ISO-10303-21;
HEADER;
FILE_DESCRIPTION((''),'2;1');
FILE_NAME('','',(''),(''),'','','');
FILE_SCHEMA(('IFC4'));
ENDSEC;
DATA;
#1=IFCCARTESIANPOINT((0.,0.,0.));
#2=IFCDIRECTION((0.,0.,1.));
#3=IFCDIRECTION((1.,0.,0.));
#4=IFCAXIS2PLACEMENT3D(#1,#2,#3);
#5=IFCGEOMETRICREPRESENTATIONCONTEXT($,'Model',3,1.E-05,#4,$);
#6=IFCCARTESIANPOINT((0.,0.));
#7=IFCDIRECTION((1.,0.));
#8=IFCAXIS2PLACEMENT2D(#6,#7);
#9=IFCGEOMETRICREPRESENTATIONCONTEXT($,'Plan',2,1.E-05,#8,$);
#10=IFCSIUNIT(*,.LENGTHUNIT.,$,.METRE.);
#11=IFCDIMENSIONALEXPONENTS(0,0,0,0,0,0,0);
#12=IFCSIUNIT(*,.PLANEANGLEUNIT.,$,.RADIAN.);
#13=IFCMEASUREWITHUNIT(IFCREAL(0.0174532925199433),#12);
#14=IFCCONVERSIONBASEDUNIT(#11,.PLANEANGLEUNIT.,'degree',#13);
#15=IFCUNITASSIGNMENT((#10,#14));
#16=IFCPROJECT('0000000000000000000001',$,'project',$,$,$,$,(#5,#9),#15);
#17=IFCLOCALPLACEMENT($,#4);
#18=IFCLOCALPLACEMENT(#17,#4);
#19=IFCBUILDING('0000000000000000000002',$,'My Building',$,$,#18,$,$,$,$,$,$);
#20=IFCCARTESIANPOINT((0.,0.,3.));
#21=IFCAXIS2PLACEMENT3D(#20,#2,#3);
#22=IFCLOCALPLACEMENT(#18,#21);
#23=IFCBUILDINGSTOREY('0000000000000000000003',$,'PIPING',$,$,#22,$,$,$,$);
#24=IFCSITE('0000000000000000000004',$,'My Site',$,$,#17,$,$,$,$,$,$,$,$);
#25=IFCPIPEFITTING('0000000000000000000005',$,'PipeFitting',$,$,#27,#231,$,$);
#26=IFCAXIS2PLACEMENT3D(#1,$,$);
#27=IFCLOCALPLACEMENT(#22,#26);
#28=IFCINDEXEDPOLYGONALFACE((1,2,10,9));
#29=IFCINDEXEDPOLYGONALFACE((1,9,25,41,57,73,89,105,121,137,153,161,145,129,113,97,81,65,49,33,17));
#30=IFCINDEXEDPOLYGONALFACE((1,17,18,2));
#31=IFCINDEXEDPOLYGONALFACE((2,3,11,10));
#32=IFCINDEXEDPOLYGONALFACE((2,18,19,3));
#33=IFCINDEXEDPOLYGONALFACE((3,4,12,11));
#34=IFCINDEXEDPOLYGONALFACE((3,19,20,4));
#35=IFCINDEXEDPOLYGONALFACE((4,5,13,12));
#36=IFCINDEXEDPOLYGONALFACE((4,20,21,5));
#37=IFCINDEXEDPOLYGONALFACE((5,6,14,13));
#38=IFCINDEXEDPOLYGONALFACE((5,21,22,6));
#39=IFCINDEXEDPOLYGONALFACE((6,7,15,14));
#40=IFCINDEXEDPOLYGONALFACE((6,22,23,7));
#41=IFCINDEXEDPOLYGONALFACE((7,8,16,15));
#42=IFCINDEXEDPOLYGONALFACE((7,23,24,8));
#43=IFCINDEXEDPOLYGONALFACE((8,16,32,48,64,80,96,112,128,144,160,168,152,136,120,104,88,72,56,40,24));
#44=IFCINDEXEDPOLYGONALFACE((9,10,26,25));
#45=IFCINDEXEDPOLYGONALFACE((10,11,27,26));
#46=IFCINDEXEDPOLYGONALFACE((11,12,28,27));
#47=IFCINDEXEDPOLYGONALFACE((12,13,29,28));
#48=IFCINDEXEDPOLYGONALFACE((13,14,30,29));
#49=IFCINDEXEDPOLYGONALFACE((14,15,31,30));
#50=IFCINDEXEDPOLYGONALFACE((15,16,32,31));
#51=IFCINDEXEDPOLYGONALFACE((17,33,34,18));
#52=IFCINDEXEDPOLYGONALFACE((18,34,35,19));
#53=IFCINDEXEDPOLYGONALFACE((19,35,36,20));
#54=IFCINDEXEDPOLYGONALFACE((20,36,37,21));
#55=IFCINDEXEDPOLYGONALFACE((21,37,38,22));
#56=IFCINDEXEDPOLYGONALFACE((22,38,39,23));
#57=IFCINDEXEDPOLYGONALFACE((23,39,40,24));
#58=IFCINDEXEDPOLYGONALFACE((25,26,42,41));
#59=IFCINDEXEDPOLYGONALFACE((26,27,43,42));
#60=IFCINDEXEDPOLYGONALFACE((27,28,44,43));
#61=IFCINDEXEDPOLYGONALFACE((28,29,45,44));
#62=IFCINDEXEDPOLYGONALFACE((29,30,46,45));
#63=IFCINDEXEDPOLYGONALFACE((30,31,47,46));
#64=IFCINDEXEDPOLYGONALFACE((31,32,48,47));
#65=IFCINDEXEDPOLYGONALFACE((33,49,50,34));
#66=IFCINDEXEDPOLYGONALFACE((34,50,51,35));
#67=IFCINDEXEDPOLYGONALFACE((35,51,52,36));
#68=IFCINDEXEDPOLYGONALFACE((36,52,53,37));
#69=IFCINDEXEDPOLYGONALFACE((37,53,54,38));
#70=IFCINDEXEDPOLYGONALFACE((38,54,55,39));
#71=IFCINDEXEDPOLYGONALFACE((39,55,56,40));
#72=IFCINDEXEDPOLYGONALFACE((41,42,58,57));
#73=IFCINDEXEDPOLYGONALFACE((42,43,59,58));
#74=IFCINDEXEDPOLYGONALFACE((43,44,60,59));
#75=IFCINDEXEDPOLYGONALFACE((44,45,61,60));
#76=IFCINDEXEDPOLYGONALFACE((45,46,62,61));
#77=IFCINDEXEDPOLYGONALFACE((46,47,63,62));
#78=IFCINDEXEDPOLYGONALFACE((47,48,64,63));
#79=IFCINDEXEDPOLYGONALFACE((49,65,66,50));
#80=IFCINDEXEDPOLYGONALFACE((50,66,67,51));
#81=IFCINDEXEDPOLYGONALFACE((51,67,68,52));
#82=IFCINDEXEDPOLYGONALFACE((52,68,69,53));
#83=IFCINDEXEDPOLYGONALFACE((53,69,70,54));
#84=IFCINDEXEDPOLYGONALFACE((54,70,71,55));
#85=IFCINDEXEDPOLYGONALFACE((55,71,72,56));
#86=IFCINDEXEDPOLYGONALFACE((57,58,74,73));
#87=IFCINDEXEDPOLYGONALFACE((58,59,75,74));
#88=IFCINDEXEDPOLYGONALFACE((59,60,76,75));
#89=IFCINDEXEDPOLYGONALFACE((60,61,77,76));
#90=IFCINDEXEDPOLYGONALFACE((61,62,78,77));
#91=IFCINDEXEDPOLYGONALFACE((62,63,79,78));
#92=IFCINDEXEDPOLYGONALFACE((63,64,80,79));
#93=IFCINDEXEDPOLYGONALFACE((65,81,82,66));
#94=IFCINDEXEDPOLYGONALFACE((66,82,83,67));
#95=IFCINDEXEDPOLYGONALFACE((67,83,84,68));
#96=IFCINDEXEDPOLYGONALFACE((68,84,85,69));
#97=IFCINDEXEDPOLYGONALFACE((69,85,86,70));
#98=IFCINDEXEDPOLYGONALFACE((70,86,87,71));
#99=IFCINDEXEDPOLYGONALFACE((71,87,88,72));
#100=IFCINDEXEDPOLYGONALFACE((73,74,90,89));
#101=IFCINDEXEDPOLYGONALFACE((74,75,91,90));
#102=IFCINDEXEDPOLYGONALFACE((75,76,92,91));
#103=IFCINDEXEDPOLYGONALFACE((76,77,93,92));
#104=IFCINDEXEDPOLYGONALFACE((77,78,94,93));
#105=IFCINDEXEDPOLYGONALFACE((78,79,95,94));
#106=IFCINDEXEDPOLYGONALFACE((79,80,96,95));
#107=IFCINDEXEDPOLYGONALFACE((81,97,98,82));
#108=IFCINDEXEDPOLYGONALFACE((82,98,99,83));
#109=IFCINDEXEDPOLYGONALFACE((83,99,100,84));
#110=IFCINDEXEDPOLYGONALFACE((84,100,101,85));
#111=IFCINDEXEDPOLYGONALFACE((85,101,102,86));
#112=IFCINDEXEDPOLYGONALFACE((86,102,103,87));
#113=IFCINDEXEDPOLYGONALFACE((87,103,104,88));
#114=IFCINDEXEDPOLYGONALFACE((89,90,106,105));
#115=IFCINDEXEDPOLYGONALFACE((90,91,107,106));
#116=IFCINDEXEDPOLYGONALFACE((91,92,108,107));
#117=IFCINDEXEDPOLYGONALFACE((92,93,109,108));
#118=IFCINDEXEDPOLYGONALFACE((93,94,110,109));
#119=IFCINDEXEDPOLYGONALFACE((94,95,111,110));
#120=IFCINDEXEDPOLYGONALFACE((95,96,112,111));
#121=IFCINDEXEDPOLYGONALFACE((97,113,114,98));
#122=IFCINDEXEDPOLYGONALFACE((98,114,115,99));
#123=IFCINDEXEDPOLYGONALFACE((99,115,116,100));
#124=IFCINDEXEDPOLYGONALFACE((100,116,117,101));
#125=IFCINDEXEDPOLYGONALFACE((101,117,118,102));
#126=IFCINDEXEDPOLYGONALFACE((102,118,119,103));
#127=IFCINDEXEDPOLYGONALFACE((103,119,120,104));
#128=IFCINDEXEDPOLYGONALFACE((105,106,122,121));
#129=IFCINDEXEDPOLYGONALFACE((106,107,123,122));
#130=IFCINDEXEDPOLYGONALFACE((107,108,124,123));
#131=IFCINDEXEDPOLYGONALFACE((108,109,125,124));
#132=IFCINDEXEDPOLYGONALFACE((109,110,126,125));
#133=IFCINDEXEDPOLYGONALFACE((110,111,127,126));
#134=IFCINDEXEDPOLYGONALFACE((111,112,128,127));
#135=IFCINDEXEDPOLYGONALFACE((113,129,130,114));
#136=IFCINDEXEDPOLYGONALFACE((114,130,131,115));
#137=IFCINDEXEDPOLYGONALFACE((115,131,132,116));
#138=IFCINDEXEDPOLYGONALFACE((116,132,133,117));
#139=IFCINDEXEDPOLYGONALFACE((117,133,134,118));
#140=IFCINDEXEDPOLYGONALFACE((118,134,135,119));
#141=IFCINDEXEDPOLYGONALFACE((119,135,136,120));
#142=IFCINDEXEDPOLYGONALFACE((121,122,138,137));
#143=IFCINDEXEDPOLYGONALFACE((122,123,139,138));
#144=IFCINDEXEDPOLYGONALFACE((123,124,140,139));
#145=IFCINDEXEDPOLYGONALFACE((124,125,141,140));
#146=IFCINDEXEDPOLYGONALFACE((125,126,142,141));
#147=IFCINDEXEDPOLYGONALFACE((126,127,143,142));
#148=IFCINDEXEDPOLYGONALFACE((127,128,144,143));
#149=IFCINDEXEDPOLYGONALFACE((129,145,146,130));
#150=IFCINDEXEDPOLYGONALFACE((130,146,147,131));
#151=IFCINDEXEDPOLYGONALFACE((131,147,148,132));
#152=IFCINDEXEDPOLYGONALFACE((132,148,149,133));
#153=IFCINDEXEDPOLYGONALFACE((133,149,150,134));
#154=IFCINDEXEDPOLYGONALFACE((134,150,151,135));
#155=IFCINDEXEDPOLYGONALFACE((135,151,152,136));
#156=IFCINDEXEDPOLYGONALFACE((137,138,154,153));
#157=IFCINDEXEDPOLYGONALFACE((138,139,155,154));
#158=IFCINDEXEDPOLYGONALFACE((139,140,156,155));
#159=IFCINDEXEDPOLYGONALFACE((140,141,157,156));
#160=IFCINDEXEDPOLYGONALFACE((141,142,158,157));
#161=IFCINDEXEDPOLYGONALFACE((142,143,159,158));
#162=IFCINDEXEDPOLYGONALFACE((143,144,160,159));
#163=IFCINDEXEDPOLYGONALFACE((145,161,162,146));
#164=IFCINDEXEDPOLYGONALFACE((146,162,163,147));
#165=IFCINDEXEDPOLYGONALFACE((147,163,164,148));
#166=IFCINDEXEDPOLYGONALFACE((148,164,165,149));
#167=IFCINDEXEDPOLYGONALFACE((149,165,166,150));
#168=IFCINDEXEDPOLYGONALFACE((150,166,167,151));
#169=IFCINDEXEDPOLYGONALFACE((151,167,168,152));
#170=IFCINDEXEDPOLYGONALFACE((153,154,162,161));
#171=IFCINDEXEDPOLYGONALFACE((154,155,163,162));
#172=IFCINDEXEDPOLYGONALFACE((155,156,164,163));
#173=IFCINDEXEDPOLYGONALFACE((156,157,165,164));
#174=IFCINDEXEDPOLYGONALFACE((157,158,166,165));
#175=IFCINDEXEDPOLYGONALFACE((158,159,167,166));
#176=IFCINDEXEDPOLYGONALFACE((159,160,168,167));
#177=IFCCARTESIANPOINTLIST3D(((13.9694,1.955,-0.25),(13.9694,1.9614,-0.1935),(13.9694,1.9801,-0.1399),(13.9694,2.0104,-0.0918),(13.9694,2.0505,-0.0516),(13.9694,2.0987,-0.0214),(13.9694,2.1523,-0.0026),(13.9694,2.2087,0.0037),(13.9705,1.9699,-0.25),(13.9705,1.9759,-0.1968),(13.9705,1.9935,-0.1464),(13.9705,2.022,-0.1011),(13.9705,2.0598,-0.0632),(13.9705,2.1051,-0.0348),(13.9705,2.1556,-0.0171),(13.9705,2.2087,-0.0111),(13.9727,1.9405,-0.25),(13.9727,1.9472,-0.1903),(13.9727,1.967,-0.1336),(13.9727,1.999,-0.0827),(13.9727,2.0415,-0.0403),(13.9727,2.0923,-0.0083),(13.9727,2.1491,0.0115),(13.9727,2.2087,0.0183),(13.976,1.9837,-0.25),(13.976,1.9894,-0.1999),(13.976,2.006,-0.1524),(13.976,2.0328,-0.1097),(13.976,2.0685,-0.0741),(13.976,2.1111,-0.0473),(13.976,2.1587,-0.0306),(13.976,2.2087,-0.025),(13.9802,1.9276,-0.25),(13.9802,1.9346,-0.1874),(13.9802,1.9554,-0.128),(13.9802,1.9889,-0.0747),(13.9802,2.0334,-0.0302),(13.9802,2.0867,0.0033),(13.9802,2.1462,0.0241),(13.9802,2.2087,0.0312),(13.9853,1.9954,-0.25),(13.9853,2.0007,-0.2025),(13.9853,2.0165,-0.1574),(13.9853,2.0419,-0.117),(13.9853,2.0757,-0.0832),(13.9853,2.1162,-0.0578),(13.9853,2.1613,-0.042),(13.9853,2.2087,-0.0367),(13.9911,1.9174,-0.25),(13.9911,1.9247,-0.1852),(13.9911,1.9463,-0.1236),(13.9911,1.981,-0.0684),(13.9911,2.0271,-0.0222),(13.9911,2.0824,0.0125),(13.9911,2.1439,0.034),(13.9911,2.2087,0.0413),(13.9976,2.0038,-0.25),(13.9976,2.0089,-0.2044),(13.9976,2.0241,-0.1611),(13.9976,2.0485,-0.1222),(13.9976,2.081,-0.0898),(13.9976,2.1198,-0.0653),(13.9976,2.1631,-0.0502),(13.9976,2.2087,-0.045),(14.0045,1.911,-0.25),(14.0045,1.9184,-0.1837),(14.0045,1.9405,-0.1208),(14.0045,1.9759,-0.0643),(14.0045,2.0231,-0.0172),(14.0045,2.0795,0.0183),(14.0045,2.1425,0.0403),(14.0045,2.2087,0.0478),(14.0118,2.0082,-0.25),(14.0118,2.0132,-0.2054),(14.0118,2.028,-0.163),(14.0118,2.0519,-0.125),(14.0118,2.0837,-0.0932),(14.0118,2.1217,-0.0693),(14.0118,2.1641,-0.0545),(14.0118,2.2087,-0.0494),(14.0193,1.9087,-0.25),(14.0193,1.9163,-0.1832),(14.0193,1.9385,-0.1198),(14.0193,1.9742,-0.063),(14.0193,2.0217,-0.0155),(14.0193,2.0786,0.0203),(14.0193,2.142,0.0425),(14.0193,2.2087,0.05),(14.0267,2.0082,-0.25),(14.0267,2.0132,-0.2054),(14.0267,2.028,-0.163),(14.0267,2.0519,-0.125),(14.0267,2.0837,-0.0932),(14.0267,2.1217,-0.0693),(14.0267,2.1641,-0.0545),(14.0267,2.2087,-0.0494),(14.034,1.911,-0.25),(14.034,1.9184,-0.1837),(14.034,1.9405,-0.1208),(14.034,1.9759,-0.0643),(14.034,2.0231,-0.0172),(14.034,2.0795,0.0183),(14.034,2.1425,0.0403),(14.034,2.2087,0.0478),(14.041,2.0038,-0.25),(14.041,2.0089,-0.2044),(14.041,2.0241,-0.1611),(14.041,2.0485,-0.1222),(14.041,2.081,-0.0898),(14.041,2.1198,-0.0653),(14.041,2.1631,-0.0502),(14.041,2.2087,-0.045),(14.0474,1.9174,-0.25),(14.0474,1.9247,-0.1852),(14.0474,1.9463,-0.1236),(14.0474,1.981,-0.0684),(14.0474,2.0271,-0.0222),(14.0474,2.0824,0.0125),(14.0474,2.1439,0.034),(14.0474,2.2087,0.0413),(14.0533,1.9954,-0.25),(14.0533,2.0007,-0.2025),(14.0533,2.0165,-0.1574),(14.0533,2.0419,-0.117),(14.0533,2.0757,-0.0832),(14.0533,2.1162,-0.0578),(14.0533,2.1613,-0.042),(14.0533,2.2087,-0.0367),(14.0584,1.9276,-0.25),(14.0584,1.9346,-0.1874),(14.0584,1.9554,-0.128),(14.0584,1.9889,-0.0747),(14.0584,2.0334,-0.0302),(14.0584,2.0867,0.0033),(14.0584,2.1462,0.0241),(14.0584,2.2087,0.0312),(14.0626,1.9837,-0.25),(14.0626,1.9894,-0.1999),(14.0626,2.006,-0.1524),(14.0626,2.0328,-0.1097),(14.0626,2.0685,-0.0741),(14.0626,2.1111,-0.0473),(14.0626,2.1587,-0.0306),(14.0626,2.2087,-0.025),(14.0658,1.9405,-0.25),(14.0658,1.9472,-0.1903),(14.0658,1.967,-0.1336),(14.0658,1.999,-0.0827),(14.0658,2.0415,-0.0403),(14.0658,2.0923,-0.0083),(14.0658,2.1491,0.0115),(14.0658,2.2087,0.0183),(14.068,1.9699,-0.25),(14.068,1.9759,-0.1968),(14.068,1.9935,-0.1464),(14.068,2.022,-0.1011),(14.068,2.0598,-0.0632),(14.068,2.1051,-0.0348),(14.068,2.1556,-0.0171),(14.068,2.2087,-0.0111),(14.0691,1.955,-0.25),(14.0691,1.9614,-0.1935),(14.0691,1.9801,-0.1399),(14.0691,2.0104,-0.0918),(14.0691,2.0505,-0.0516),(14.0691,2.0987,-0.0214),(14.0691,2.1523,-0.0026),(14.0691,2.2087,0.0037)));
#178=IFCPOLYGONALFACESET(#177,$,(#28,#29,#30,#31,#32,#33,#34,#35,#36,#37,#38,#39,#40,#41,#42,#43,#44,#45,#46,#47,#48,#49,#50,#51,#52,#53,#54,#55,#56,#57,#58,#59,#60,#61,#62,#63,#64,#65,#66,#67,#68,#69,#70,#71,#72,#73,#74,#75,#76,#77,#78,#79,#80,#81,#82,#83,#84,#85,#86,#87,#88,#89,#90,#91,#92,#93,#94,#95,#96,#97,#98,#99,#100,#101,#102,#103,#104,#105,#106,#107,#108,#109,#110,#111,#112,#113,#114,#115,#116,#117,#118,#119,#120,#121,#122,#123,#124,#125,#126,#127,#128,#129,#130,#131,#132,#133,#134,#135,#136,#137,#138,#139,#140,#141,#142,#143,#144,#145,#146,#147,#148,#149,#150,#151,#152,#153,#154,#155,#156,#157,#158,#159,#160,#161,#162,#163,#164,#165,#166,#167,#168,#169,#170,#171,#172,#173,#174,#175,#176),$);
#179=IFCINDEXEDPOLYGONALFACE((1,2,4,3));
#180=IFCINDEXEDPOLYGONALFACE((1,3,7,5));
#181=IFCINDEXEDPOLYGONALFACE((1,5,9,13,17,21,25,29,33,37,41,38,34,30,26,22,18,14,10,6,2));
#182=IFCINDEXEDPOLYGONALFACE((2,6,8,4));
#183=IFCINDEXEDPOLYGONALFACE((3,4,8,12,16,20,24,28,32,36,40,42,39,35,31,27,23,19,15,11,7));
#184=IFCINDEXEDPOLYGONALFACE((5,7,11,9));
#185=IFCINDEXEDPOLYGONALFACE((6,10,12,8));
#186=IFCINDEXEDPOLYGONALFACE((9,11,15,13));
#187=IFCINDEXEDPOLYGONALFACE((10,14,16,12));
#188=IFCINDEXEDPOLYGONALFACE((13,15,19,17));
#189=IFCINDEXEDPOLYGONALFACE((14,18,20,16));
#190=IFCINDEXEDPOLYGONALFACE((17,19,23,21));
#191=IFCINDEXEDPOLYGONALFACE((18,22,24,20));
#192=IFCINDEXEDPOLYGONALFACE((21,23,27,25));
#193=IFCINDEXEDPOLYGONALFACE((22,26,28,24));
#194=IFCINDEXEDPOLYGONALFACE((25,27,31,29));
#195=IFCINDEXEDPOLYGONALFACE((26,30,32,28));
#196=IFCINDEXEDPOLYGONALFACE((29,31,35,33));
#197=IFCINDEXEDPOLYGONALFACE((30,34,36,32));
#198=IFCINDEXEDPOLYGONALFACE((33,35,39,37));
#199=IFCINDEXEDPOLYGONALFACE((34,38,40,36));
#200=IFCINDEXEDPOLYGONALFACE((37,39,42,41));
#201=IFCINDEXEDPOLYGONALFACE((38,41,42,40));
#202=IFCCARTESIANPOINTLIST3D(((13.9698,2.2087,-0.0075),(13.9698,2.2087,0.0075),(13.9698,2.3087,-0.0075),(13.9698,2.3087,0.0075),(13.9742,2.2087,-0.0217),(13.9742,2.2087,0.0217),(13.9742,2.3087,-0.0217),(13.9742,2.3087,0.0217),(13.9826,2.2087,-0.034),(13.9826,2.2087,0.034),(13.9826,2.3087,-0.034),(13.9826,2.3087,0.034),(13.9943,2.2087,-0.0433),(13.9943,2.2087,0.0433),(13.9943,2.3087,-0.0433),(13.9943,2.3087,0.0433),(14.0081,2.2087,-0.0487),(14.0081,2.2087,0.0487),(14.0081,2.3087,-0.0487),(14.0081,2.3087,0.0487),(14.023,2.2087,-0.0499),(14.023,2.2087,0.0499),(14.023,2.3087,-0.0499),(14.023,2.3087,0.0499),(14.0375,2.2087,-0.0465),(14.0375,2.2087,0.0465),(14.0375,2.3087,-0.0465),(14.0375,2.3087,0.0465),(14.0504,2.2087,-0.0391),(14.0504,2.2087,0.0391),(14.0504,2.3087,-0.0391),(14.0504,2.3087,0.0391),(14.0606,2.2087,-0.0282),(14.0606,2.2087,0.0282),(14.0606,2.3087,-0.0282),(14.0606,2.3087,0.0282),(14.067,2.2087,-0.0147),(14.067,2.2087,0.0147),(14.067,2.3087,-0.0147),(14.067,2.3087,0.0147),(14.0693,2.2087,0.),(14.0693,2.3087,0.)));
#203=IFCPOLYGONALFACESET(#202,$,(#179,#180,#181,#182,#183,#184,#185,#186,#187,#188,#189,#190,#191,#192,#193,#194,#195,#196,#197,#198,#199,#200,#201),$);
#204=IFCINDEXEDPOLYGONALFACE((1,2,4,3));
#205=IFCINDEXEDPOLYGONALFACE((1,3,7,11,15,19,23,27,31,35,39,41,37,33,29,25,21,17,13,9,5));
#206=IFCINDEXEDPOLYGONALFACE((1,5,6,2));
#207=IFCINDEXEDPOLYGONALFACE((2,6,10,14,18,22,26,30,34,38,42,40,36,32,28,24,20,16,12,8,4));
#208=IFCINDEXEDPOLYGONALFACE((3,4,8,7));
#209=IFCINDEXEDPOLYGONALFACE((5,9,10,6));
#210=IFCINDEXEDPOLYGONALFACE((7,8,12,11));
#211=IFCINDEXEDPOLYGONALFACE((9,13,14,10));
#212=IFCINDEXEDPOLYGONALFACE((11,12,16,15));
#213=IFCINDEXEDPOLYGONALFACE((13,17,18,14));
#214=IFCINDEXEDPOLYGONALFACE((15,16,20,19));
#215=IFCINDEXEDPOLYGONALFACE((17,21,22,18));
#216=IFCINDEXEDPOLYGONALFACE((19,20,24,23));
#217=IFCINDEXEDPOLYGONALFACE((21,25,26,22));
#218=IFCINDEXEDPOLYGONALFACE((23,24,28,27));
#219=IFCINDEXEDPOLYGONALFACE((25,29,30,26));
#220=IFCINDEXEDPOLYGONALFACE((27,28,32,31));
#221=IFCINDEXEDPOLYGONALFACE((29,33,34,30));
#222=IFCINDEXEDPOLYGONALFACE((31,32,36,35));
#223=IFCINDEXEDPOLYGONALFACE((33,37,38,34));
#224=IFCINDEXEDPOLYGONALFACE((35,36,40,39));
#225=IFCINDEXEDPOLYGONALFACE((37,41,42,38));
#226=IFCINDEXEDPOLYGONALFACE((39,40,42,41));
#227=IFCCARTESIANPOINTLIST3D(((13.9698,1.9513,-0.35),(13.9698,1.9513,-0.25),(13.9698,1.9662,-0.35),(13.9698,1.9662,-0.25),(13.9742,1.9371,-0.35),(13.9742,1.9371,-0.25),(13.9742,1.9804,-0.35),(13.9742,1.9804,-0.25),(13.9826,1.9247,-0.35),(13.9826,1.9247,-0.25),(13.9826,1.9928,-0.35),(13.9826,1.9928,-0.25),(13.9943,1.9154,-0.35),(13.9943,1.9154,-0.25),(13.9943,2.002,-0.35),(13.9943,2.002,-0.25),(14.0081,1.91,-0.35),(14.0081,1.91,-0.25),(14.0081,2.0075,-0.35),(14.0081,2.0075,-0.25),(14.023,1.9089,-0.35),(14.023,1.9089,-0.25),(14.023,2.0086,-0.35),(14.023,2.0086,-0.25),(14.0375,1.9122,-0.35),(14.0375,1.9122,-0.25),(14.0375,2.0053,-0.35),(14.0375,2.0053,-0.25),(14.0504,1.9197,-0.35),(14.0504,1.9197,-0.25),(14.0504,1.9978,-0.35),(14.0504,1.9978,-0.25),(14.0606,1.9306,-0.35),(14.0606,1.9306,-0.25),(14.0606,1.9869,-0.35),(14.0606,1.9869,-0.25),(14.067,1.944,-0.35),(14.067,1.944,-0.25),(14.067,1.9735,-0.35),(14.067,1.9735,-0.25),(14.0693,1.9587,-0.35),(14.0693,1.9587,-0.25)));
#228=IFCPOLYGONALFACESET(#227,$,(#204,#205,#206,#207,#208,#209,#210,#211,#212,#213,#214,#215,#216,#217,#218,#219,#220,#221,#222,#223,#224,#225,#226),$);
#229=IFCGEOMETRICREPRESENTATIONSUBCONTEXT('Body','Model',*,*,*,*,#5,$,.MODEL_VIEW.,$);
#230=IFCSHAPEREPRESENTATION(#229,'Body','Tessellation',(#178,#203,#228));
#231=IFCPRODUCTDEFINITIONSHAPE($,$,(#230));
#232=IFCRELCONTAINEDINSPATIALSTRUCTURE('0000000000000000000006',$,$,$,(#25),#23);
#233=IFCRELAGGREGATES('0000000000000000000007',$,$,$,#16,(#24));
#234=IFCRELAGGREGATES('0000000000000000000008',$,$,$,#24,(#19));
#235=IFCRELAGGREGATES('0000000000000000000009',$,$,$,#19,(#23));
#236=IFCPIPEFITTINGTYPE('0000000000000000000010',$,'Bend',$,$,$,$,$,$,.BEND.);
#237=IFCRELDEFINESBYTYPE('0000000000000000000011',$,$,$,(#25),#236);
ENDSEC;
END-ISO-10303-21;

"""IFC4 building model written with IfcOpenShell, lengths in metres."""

from ifc_helpers import new_model, entity, si_unit, converted_unit, frame, origin_with_axes, origin_2d_with_axis, place, context, subcontext, project, spatial, circle, extrude, source, transform, mapped, type_object, type_shapes, element, save


model = new_model("IFC4")

# Units and contexts
model_context = context("Model", 3, precision=1e-05, world=origin_with_axes())
plan_context = context("Plan", 2, precision=1e-05, world=origin_2d_with_axis())
body_context = subcontext(model_context, "Body", "Model", "MODEL_VIEW")
ifc_project = project(units=[si_unit("LENGTHUNIT", "METRE"), converted_unit("PLANEANGLEUNIT", "degree", entity("IfcReal", 0.0174532925199433), si_unit("PLANEANGLEUNIT", "RADIAN"), dimensions=[0, 0, 0, 0, 0, 0, 0])], contexts=[model_context, plan_context])

# Site, building, storey
site_placement = place(None, origin_with_axes())
site = spatial("IfcSite", under=ifc_project, at=site_placement, Name="My Site")
building_placement = place(site_placement, origin_with_axes())
building = spatial("IfcBuilding", under=site, at=building_placement, Name="My Building")
storey_placement = place(building_placement, frame((0.0, 0.0, 3.0), z_axis=(0.0, 0.0, 1.0), x_axis=(1.0, 0.0, 0.0)))
storey = spatial("IfcBuildingStorey", under=building, at=storey_placement, Name="PIPING")

# Pipe fitting
pipe_fitting_type = type_object("IfcPipeFittingType", Name="Bend", PredefinedType="BEND")
shared_shape = source(origin_with_axes(), body_context, "Body", "SolidModel", [
    entity("IfcSweptDiskSolid", entity("IfcIndexedPolyCurve", entity("IfcCartesianPointList3D", [[0.0, 0.0, 0.1], [0.0, -0.0732, 0.2768], [0.0, -0.25, 0.35]]), [entity("IfcArcIndex", [1, 2, 3])]), 0.05),
    extrude(circle(Radius=0.05), origin_with_axes(), (0.0, 0.0, 1.0), 0.1),
    extrude(circle(Radius=0.05), frame((0.0, -0.25, 0.35), z_axis=(0.0, -1.0, 0.0), x_axis=(1.0, 0.0, 0.0)), (0.0, 0.0, 1.0), 0.1),
])
type_shapes(pipe_fitting_type, [shared_shape])
for number, where, z_axis, x_axis, name in (
    (1, (14.0193, 2.3087, 0.0), (0.0, -1.0, 0.0), (1.0, 0.0, 0.0), "PipeFitting"),
):
    element("IfcPipeFitting", number, at=place(storey_placement, frame(where, z_axis=z_axis, x_axis=x_axis)), inside=storey, type_object=pipe_fitting_type, Name=name, context=body_context, shape_type="MappedRepresentation", body=[
        mapped(shared_shape, transform((0.0, 0.0, 0.0), x_axis=(1.0, 0.0, 0.0), y_axis=(0.0, 1.0, 0.0), z_axis=(0.0, 0.0, 1.0), scale=1.0)),
    ])

save(model, "model.ifc")
